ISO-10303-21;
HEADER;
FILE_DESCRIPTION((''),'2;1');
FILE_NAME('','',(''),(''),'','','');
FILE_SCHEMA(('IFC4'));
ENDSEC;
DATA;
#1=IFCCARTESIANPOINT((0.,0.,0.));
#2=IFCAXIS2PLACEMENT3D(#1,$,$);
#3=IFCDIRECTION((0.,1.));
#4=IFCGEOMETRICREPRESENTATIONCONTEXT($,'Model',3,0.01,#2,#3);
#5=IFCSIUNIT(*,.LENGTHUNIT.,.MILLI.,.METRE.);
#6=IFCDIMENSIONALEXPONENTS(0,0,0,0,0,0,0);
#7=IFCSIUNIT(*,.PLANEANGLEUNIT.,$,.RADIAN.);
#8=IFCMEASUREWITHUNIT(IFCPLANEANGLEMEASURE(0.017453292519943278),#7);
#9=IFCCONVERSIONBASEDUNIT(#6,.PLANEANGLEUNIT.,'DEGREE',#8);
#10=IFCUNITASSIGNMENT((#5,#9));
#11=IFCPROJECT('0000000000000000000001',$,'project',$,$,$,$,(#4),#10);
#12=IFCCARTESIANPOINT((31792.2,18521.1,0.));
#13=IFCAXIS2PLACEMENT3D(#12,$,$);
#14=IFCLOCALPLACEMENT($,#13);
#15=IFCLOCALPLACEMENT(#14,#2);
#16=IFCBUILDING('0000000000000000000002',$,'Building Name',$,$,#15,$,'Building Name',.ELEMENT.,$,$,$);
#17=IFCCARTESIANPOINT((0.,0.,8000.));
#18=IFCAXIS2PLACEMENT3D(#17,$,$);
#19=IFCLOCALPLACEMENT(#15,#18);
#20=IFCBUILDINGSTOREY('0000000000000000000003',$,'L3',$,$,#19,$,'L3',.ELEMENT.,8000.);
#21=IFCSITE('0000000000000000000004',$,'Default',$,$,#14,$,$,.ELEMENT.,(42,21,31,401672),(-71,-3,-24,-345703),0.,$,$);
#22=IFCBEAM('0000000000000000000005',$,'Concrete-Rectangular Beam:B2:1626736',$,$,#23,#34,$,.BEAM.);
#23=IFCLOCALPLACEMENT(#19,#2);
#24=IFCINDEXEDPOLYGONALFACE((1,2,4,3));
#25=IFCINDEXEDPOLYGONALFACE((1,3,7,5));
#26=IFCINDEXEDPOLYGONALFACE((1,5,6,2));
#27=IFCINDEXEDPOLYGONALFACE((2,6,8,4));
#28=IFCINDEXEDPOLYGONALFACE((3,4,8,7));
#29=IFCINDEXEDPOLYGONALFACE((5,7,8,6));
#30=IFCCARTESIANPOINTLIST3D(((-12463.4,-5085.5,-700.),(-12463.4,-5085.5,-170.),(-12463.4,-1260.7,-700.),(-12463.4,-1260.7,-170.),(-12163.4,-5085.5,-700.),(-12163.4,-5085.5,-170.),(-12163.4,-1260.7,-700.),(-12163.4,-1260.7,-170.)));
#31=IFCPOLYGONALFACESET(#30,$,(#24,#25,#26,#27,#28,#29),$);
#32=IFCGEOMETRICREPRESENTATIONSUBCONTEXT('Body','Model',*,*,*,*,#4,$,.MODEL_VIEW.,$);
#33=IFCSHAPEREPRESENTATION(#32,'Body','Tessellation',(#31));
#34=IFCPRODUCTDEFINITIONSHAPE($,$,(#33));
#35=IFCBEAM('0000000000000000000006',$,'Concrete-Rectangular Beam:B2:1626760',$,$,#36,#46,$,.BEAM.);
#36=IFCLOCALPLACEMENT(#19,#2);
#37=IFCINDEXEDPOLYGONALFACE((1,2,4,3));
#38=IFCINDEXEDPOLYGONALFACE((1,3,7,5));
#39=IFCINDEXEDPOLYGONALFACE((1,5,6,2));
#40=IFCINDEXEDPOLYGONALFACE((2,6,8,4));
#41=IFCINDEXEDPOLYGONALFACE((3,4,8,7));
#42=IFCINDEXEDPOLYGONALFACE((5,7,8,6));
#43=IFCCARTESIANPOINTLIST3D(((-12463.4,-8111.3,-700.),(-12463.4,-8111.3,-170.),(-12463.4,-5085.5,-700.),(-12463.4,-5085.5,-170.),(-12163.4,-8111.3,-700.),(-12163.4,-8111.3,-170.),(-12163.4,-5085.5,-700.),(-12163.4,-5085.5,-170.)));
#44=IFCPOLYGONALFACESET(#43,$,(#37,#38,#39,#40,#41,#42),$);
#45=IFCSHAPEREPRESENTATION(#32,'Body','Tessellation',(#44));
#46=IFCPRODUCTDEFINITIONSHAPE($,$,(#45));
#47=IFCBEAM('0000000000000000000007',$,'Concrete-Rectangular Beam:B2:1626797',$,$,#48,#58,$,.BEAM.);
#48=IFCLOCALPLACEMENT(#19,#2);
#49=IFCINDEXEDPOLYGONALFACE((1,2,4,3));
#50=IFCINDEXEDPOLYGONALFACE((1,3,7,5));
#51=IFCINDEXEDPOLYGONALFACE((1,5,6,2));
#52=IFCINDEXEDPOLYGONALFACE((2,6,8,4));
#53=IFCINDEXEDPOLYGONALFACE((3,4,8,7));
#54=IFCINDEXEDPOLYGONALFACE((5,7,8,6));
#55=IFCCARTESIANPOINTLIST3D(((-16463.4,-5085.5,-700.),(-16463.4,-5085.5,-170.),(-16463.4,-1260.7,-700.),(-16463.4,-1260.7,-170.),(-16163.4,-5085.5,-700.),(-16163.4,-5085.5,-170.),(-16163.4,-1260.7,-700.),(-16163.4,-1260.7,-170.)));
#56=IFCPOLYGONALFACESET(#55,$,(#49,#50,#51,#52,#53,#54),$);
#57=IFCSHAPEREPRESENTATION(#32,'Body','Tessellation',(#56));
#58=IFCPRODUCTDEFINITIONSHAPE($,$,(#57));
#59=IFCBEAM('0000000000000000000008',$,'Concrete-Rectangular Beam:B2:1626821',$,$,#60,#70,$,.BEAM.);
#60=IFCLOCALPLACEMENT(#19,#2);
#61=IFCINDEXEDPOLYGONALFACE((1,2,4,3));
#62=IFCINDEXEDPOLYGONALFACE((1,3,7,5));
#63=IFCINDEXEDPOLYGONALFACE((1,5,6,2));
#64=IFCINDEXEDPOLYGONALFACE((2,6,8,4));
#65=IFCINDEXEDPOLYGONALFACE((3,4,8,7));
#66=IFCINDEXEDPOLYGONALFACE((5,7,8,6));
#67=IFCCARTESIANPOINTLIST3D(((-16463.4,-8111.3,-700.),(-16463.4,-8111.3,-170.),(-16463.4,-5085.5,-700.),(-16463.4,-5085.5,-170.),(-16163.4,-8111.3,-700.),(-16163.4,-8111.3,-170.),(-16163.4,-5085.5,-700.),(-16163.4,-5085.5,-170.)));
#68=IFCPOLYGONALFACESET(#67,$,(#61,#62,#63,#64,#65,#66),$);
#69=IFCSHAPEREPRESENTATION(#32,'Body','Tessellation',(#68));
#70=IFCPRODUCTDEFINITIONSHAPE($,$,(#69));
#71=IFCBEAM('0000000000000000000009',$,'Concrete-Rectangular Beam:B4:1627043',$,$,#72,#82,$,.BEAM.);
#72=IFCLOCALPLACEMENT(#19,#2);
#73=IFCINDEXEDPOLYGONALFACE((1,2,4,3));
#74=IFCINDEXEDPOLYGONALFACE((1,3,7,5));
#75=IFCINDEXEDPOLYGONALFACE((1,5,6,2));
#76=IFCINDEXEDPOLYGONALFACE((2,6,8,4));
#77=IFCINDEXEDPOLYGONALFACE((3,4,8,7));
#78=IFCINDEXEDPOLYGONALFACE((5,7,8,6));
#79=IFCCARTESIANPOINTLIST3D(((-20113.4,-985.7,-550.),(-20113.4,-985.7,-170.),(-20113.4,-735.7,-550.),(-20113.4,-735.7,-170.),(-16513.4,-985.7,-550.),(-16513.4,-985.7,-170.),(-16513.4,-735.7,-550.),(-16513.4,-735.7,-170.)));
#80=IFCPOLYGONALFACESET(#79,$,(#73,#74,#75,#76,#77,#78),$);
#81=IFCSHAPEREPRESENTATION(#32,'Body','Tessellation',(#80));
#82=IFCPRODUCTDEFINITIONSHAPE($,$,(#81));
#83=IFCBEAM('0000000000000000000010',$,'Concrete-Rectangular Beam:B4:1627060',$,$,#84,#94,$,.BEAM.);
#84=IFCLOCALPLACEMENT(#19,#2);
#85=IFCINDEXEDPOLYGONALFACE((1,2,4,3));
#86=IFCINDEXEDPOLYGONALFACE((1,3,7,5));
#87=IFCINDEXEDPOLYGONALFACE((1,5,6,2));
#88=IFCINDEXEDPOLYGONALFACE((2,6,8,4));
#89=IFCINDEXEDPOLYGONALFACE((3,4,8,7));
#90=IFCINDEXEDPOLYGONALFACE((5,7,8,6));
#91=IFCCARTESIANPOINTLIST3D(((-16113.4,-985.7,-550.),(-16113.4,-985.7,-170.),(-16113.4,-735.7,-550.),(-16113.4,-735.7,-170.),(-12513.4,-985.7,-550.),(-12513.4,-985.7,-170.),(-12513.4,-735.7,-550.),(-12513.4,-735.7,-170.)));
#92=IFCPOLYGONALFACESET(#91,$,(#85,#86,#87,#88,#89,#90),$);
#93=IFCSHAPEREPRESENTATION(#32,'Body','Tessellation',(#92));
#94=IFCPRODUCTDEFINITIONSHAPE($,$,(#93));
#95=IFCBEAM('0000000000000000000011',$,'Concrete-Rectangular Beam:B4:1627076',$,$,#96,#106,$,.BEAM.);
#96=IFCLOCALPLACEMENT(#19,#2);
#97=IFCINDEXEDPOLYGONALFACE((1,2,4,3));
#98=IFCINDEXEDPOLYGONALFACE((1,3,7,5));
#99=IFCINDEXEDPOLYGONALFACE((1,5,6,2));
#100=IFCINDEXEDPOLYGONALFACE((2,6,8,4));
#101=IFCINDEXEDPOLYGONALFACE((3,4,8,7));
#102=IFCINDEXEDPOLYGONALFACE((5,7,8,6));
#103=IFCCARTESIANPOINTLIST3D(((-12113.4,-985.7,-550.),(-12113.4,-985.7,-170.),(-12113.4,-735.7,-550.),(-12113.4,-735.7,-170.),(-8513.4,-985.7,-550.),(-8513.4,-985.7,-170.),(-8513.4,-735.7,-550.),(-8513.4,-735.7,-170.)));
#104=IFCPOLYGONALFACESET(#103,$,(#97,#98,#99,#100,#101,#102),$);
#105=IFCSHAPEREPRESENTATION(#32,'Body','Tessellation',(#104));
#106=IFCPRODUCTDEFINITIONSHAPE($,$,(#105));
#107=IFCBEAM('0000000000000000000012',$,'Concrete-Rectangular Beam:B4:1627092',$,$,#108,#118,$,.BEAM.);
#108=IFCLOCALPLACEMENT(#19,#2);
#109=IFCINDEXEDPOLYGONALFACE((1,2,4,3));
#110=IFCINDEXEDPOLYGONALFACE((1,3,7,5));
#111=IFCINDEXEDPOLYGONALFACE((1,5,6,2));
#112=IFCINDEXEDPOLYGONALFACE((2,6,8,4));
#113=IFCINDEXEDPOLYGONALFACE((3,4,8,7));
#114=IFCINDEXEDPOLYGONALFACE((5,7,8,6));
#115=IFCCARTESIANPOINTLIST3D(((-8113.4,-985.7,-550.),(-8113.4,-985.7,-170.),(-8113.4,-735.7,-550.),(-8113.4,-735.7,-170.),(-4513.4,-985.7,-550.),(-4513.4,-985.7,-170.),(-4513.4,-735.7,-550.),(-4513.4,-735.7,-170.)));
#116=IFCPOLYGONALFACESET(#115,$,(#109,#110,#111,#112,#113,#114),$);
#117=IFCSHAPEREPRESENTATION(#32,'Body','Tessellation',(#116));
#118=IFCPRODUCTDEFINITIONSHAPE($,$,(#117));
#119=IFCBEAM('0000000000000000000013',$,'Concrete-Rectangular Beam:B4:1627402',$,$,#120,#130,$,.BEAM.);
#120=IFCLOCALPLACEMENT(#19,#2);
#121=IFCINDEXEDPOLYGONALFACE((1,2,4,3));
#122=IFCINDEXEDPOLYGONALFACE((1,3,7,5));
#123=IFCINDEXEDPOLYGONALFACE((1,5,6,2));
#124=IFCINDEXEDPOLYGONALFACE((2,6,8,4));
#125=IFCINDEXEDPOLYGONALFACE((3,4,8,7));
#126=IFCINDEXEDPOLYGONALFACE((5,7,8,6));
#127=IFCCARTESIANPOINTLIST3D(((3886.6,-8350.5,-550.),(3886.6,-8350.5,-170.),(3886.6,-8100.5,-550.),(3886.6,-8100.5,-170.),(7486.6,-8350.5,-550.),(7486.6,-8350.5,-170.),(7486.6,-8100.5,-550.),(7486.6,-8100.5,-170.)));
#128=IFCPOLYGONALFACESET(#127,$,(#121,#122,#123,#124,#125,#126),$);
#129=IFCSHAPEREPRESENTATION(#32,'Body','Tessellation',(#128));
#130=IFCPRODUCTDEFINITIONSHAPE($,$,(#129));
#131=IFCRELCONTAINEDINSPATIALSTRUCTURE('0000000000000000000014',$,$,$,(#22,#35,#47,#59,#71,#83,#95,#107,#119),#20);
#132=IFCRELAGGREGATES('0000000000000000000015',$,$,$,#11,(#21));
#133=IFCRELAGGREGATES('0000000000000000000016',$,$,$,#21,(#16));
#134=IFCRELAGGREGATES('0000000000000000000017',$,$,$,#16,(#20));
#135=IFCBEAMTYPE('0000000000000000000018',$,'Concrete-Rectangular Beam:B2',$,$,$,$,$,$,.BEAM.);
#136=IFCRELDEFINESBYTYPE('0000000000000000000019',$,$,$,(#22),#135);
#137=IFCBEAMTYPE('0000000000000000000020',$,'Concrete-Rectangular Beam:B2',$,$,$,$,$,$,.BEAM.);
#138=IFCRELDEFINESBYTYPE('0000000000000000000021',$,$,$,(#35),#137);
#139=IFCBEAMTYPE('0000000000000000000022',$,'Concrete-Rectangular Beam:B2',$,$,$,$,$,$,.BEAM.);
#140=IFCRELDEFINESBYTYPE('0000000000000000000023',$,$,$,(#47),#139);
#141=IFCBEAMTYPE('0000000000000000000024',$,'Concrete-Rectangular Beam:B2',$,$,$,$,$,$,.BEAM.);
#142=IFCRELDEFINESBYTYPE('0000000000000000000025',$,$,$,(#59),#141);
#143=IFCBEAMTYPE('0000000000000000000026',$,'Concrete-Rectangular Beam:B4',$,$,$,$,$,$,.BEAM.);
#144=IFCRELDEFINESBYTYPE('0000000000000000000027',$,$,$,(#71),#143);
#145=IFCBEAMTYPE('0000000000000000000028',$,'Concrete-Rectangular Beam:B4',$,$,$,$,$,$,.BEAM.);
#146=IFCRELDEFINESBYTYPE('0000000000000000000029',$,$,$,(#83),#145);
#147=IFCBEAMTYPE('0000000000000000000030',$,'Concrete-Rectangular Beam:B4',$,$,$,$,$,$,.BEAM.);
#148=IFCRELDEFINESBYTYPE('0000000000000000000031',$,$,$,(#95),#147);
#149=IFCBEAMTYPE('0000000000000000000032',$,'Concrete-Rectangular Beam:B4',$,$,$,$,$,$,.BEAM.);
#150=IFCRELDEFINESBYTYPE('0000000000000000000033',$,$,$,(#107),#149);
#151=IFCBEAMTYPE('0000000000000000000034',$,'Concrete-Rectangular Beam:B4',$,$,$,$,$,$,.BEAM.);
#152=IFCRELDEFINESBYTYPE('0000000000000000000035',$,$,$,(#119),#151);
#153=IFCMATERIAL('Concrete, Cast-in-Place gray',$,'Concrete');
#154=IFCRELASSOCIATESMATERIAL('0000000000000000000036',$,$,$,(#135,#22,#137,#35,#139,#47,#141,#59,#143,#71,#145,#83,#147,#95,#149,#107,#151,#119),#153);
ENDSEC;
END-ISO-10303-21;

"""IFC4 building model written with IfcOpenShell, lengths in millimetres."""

from ifc_helpers import new_model, entity, si_unit, converted_unit, direction, frame, origin, place, context, subcontext, project, spatial, indexed_curve, outline, extrude, source, transform, mapped, material, type_object, type_shapes, element, save


model = new_model("IFC4")

# Units and contexts
model_context = context("Model", 3, precision=0.01, world=origin(), true_north=direction((0.0, 1.0)))
body_context = subcontext(model_context, "Body", "Model", "MODEL_VIEW")
ifc_project = project(units=[si_unit("LENGTHUNIT", "METRE", prefix="MILLI"), converted_unit("PLANEANGLEUNIT", "DEGREE", entity("IfcPlaneAngleMeasure", 0.017453292519943278), si_unit("PLANEANGLEUNIT", "RADIAN"), dimensions=[0, 0, 0, 0, 0, 0, 0])], contexts=[model_context])

# Site, building, storey
site_placement = place(None, frame((31792.2, 18521.1, 0.0)))
site = spatial("IfcSite", under=ifc_project, at=site_placement, Name="Default", CompositionType="ELEMENT", RefLatitude=(42, 21, 31, 401672), RefLongitude=(-71, -3, -24, -345703), RefElevation=0.0)
building_placement = place(site_placement, origin())
building = spatial("IfcBuilding", under=site, at=building_placement, Name="Building Name", LongName="Building Name", CompositionType="ELEMENT")
storey_placement = place(building_placement, frame((0.0, 0.0, 8000.0)))
storey = spatial("IfcBuildingStorey", under=building, at=storey_placement, Name="L3", LongName="L3", CompositionType="ELEMENT", Elevation=8000.0)

# Beams
ifc_material = material(Name="Concrete, Cast-in-Place gray", Category="Concrete")
beam_type_1 = type_object("IfcBeamType", Name="Concrete-Rectangular Beam:B2", PredefinedType="BEAM", material=ifc_material)
shared_shape_1 = source(origin(), body_context, "Body", "SweptSolid", [
    extrude(outline(indexed_curve([(-150.0, -265.0), (150.0, -265.0), (150.0, 265.0), (-150.0, 265.0), (-150.0, -265.0)], self_intersect=False)), frame((-12313.4, -1260.7, 7565.0), z_axis=(0.0, -1.0, 0.0), x_axis=(-1.0, 0.0, 0.0)), (0.0, 0.0, 1.0), 3824.8),
])
type_shapes(beam_type_1, [shared_shape_1])
beam_1_placement = place(storey_placement, frame((0.0, 0.0, -8000.0)))
element("IfcBeam", 1, at=beam_1_placement, inside=storey, type_object=beam_type_1, material=ifc_material, Name="Concrete-Rectangular Beam:B2:1626736", PredefinedType="BEAM", context=body_context, shape_type="MappedRepresentation", body=[
    mapped(shared_shape_1, transform((0.0, 0.0, 0.0), scale=1.0)),
])
beam_type_2 = type_object("IfcBeamType", Name="Concrete-Rectangular Beam:B2", PredefinedType="BEAM", material=ifc_material)
shared_shape_2 = source(origin(), body_context, "Body", "SweptSolid", [
    extrude(outline(indexed_curve([(-150.0, -265.0), (150.0, -265.0), (150.0, 265.0), (-150.0, 265.0), (-150.0, -265.0)], self_intersect=False)), frame((-12313.4, -5085.5, 7565.0), z_axis=(0.0, -1.0, 0.0), x_axis=(-1.0, 0.0, 0.0)), (0.0, 0.0, 1.0), 3025.8),
])
type_shapes(beam_type_2, [shared_shape_2])
beam_2_placement = place(storey_placement, frame((0.0, 0.0, -8000.0)))
element("IfcBeam", 2, at=beam_2_placement, inside=storey, type_object=beam_type_2, material=ifc_material, Name="Concrete-Rectangular Beam:B2:1626760", PredefinedType="BEAM", context=body_context, shape_type="MappedRepresentation", body=[
    mapped(shared_shape_2, transform((0.0, 0.0, 0.0), scale=1.0)),
])
beam_type_3 = type_object("IfcBeamType", Name="Concrete-Rectangular Beam:B2", PredefinedType="BEAM", material=ifc_material)
shared_shape_3 = source(origin(), body_context, "Body", "SweptSolid", [
    extrude(outline(indexed_curve([(-150.0, -265.0), (150.0, -265.0), (150.0, 265.0), (-150.0, 265.0), (-150.0, -265.0)], self_intersect=False)), frame((-16313.4, -1260.7, 7565.0), z_axis=(0.0, -1.0, 0.0), x_axis=(-1.0, 0.0, 0.0)), (0.0, 0.0, 1.0), 3824.8),
])
type_shapes(beam_type_3, [shared_shape_3])
beam_3_placement = place(storey_placement, frame((0.0, 0.0, -8000.0)))
element("IfcBeam", 3, at=beam_3_placement, inside=storey, type_object=beam_type_3, material=ifc_material, Name="Concrete-Rectangular Beam:B2:1626797", PredefinedType="BEAM", context=body_context, shape_type="MappedRepresentation", body=[
    mapped(shared_shape_3, transform((0.0, 0.0, 0.0), scale=1.0)),
])
beam_type_4 = type_object("IfcBeamType", Name="Concrete-Rectangular Beam:B2", PredefinedType="BEAM", material=ifc_material)
shared_shape_4 = source(origin(), body_context, "Body", "SweptSolid", [
    extrude(outline(indexed_curve([(-150.0, -265.0), (150.0, -265.0), (150.0, 265.0), (-150.0, 265.0), (-150.0, -265.0)], self_intersect=False)), frame((-16313.4, -5085.5, 7565.0), z_axis=(0.0, -1.0, 0.0), x_axis=(-1.0, 0.0, 0.0)), (0.0, 0.0, 1.0), 3025.8),
])
type_shapes(beam_type_4, [shared_shape_4])
beam_4_placement = place(storey_placement, frame((0.0, 0.0, -8000.0)))
element("IfcBeam", 4, at=beam_4_placement, inside=storey, type_object=beam_type_4, material=ifc_material, Name="Concrete-Rectangular Beam:B2:1626821", PredefinedType="BEAM", context=body_context, shape_type="MappedRepresentation", body=[
    mapped(shared_shape_4, transform((0.0, 0.0, 0.0), scale=1.0)),
])
beam_type_5 = type_object("IfcBeamType", Name="Concrete-Rectangular Beam:B4", PredefinedType="BEAM", material=ifc_material)
shared_shape_5 = source(origin(), body_context, "Body", "SweptSolid", [
    extrude(outline(indexed_curve([(-190.0, -125.0), (190.0, -125.0), (190.0, 125.0), (-190.0, 125.0), (-190.0, -125.0)], self_intersect=False)), frame((-20113.4, -860.7, 7640.0), z_axis=(1.0, 0.0, 0.0), x_axis=(0.0, 0.0, -1.0)), (0.0, 0.0, 1.0), 3600.0),
])
type_shapes(beam_type_5, [shared_shape_5])
beam_5_placement = place(storey_placement, frame((0.0, 0.0, -8000.0)))
element("IfcBeam", 5, at=beam_5_placement, inside=storey, type_object=beam_type_5, material=ifc_material, Name="Concrete-Rectangular Beam:B4:1627043", PredefinedType="BEAM", context=body_context, shape_type="MappedRepresentation", body=[
    mapped(shared_shape_5, transform((0.0, 0.0, 0.0), scale=1.0)),
])
beam_type_6 = type_object("IfcBeamType", Name="Concrete-Rectangular Beam:B4", PredefinedType="BEAM", material=ifc_material)
shared_shape_6 = source(origin(), body_context, "Body", "SweptSolid", [
    extrude(outline(indexed_curve([(-190.0, -125.0), (190.0, -125.0), (190.0, 125.0), (-190.0, 125.0), (-190.0, -125.0)], self_intersect=False)), frame((-16113.4, -860.7, 7640.0), z_axis=(1.0, 0.0, 0.0), x_axis=(0.0, 0.0, -1.0)), (0.0, 0.0, 1.0), 3600.0),
])
type_shapes(beam_type_6, [shared_shape_6])
beam_6_placement = place(storey_placement, frame((0.0, 0.0, -8000.0)))
element("IfcBeam", 6, at=beam_6_placement, inside=storey, type_object=beam_type_6, material=ifc_material, Name="Concrete-Rectangular Beam:B4:1627060", PredefinedType="BEAM", context=body_context, shape_type="MappedRepresentation", body=[
    mapped(shared_shape_6, transform((0.0, 0.0, 0.0), scale=1.0)),
])
beam_type_7 = type_object("IfcBeamType", Name="Concrete-Rectangular Beam:B4", PredefinedType="BEAM", material=ifc_material)
shared_shape_7 = source(origin(), body_context, "Body", "SweptSolid", [
    extrude(outline(indexed_curve([(-190.0, -125.0), (190.0, -125.0), (190.0, 125.0), (-190.0, 125.0), (-190.0, -125.0)], self_intersect=False)), frame((-12113.4, -860.7, 7640.0), z_axis=(1.0, 0.0, 0.0), x_axis=(0.0, 0.0, -1.0)), (0.0, 0.0, 1.0), 3600.0),
])
type_shapes(beam_type_7, [shared_shape_7])
beam_7_placement = place(storey_placement, frame((0.0, 0.0, -8000.0)))
element("IfcBeam", 7, at=beam_7_placement, inside=storey, type_object=beam_type_7, material=ifc_material, Name="Concrete-Rectangular Beam:B4:1627076", PredefinedType="BEAM", context=body_context, shape_type="MappedRepresentation", body=[
    mapped(shared_shape_7, transform((0.0, 0.0, 0.0), scale=1.0)),
])
beam_type_8 = type_object("IfcBeamType", Name="Concrete-Rectangular Beam:B4", PredefinedType="BEAM", material=ifc_material)
shared_shape_8 = source(origin(), body_context, "Body", "SweptSolid", [
    extrude(outline(indexed_curve([(-190.0, -125.0), (190.0, -125.0), (190.0, 125.0), (-190.0, 125.0), (-190.0, -125.0)], self_intersect=False)), frame((-8113.4, -860.7, 7640.0), z_axis=(1.0, 0.0, 0.0), x_axis=(0.0, 0.0, -1.0)), (0.0, 0.0, 1.0), 3600.0),
])
type_shapes(beam_type_8, [shared_shape_8])
beam_8_placement = place(storey_placement, frame((0.0, 0.0, -8000.0)))
element("IfcBeam", 8, at=beam_8_placement, inside=storey, type_object=beam_type_8, material=ifc_material, Name="Concrete-Rectangular Beam:B4:1627092", PredefinedType="BEAM", context=body_context, shape_type="MappedRepresentation", body=[
    mapped(shared_shape_8, transform((0.0, 0.0, 0.0), scale=1.0)),
])
beam_type_9 = type_object("IfcBeamType", Name="Concrete-Rectangular Beam:B4", PredefinedType="BEAM", material=ifc_material)
shared_shape_9 = source(origin(), body_context, "Body", "SweptSolid", [
    extrude(outline(indexed_curve([(-190.0, -125.0), (190.0, -125.0), (190.0, 125.0), (-190.0, 125.0), (-190.0, -125.0)], self_intersect=False)), frame((3886.6, -8225.5, 7640.0), z_axis=(1.0, 0.0, 0.0), x_axis=(0.0, 0.0, -1.0)), (0.0, 0.0, 1.0), 3600.0),
])
type_shapes(beam_type_9, [shared_shape_9])
beam_9_placement = place(storey_placement, frame((0.0, 0.0, -8000.0)))
element("IfcBeam", 9, at=beam_9_placement, inside=storey, type_object=beam_type_9, material=ifc_material, Name="Concrete-Rectangular Beam:B4:1627402", PredefinedType="BEAM", context=body_context, shape_type="MappedRepresentation", body=[
    mapped(shared_shape_9, transform((0.0, 0.0, 0.0), scale=1.0)),
])

save(model, "model.ifc")
